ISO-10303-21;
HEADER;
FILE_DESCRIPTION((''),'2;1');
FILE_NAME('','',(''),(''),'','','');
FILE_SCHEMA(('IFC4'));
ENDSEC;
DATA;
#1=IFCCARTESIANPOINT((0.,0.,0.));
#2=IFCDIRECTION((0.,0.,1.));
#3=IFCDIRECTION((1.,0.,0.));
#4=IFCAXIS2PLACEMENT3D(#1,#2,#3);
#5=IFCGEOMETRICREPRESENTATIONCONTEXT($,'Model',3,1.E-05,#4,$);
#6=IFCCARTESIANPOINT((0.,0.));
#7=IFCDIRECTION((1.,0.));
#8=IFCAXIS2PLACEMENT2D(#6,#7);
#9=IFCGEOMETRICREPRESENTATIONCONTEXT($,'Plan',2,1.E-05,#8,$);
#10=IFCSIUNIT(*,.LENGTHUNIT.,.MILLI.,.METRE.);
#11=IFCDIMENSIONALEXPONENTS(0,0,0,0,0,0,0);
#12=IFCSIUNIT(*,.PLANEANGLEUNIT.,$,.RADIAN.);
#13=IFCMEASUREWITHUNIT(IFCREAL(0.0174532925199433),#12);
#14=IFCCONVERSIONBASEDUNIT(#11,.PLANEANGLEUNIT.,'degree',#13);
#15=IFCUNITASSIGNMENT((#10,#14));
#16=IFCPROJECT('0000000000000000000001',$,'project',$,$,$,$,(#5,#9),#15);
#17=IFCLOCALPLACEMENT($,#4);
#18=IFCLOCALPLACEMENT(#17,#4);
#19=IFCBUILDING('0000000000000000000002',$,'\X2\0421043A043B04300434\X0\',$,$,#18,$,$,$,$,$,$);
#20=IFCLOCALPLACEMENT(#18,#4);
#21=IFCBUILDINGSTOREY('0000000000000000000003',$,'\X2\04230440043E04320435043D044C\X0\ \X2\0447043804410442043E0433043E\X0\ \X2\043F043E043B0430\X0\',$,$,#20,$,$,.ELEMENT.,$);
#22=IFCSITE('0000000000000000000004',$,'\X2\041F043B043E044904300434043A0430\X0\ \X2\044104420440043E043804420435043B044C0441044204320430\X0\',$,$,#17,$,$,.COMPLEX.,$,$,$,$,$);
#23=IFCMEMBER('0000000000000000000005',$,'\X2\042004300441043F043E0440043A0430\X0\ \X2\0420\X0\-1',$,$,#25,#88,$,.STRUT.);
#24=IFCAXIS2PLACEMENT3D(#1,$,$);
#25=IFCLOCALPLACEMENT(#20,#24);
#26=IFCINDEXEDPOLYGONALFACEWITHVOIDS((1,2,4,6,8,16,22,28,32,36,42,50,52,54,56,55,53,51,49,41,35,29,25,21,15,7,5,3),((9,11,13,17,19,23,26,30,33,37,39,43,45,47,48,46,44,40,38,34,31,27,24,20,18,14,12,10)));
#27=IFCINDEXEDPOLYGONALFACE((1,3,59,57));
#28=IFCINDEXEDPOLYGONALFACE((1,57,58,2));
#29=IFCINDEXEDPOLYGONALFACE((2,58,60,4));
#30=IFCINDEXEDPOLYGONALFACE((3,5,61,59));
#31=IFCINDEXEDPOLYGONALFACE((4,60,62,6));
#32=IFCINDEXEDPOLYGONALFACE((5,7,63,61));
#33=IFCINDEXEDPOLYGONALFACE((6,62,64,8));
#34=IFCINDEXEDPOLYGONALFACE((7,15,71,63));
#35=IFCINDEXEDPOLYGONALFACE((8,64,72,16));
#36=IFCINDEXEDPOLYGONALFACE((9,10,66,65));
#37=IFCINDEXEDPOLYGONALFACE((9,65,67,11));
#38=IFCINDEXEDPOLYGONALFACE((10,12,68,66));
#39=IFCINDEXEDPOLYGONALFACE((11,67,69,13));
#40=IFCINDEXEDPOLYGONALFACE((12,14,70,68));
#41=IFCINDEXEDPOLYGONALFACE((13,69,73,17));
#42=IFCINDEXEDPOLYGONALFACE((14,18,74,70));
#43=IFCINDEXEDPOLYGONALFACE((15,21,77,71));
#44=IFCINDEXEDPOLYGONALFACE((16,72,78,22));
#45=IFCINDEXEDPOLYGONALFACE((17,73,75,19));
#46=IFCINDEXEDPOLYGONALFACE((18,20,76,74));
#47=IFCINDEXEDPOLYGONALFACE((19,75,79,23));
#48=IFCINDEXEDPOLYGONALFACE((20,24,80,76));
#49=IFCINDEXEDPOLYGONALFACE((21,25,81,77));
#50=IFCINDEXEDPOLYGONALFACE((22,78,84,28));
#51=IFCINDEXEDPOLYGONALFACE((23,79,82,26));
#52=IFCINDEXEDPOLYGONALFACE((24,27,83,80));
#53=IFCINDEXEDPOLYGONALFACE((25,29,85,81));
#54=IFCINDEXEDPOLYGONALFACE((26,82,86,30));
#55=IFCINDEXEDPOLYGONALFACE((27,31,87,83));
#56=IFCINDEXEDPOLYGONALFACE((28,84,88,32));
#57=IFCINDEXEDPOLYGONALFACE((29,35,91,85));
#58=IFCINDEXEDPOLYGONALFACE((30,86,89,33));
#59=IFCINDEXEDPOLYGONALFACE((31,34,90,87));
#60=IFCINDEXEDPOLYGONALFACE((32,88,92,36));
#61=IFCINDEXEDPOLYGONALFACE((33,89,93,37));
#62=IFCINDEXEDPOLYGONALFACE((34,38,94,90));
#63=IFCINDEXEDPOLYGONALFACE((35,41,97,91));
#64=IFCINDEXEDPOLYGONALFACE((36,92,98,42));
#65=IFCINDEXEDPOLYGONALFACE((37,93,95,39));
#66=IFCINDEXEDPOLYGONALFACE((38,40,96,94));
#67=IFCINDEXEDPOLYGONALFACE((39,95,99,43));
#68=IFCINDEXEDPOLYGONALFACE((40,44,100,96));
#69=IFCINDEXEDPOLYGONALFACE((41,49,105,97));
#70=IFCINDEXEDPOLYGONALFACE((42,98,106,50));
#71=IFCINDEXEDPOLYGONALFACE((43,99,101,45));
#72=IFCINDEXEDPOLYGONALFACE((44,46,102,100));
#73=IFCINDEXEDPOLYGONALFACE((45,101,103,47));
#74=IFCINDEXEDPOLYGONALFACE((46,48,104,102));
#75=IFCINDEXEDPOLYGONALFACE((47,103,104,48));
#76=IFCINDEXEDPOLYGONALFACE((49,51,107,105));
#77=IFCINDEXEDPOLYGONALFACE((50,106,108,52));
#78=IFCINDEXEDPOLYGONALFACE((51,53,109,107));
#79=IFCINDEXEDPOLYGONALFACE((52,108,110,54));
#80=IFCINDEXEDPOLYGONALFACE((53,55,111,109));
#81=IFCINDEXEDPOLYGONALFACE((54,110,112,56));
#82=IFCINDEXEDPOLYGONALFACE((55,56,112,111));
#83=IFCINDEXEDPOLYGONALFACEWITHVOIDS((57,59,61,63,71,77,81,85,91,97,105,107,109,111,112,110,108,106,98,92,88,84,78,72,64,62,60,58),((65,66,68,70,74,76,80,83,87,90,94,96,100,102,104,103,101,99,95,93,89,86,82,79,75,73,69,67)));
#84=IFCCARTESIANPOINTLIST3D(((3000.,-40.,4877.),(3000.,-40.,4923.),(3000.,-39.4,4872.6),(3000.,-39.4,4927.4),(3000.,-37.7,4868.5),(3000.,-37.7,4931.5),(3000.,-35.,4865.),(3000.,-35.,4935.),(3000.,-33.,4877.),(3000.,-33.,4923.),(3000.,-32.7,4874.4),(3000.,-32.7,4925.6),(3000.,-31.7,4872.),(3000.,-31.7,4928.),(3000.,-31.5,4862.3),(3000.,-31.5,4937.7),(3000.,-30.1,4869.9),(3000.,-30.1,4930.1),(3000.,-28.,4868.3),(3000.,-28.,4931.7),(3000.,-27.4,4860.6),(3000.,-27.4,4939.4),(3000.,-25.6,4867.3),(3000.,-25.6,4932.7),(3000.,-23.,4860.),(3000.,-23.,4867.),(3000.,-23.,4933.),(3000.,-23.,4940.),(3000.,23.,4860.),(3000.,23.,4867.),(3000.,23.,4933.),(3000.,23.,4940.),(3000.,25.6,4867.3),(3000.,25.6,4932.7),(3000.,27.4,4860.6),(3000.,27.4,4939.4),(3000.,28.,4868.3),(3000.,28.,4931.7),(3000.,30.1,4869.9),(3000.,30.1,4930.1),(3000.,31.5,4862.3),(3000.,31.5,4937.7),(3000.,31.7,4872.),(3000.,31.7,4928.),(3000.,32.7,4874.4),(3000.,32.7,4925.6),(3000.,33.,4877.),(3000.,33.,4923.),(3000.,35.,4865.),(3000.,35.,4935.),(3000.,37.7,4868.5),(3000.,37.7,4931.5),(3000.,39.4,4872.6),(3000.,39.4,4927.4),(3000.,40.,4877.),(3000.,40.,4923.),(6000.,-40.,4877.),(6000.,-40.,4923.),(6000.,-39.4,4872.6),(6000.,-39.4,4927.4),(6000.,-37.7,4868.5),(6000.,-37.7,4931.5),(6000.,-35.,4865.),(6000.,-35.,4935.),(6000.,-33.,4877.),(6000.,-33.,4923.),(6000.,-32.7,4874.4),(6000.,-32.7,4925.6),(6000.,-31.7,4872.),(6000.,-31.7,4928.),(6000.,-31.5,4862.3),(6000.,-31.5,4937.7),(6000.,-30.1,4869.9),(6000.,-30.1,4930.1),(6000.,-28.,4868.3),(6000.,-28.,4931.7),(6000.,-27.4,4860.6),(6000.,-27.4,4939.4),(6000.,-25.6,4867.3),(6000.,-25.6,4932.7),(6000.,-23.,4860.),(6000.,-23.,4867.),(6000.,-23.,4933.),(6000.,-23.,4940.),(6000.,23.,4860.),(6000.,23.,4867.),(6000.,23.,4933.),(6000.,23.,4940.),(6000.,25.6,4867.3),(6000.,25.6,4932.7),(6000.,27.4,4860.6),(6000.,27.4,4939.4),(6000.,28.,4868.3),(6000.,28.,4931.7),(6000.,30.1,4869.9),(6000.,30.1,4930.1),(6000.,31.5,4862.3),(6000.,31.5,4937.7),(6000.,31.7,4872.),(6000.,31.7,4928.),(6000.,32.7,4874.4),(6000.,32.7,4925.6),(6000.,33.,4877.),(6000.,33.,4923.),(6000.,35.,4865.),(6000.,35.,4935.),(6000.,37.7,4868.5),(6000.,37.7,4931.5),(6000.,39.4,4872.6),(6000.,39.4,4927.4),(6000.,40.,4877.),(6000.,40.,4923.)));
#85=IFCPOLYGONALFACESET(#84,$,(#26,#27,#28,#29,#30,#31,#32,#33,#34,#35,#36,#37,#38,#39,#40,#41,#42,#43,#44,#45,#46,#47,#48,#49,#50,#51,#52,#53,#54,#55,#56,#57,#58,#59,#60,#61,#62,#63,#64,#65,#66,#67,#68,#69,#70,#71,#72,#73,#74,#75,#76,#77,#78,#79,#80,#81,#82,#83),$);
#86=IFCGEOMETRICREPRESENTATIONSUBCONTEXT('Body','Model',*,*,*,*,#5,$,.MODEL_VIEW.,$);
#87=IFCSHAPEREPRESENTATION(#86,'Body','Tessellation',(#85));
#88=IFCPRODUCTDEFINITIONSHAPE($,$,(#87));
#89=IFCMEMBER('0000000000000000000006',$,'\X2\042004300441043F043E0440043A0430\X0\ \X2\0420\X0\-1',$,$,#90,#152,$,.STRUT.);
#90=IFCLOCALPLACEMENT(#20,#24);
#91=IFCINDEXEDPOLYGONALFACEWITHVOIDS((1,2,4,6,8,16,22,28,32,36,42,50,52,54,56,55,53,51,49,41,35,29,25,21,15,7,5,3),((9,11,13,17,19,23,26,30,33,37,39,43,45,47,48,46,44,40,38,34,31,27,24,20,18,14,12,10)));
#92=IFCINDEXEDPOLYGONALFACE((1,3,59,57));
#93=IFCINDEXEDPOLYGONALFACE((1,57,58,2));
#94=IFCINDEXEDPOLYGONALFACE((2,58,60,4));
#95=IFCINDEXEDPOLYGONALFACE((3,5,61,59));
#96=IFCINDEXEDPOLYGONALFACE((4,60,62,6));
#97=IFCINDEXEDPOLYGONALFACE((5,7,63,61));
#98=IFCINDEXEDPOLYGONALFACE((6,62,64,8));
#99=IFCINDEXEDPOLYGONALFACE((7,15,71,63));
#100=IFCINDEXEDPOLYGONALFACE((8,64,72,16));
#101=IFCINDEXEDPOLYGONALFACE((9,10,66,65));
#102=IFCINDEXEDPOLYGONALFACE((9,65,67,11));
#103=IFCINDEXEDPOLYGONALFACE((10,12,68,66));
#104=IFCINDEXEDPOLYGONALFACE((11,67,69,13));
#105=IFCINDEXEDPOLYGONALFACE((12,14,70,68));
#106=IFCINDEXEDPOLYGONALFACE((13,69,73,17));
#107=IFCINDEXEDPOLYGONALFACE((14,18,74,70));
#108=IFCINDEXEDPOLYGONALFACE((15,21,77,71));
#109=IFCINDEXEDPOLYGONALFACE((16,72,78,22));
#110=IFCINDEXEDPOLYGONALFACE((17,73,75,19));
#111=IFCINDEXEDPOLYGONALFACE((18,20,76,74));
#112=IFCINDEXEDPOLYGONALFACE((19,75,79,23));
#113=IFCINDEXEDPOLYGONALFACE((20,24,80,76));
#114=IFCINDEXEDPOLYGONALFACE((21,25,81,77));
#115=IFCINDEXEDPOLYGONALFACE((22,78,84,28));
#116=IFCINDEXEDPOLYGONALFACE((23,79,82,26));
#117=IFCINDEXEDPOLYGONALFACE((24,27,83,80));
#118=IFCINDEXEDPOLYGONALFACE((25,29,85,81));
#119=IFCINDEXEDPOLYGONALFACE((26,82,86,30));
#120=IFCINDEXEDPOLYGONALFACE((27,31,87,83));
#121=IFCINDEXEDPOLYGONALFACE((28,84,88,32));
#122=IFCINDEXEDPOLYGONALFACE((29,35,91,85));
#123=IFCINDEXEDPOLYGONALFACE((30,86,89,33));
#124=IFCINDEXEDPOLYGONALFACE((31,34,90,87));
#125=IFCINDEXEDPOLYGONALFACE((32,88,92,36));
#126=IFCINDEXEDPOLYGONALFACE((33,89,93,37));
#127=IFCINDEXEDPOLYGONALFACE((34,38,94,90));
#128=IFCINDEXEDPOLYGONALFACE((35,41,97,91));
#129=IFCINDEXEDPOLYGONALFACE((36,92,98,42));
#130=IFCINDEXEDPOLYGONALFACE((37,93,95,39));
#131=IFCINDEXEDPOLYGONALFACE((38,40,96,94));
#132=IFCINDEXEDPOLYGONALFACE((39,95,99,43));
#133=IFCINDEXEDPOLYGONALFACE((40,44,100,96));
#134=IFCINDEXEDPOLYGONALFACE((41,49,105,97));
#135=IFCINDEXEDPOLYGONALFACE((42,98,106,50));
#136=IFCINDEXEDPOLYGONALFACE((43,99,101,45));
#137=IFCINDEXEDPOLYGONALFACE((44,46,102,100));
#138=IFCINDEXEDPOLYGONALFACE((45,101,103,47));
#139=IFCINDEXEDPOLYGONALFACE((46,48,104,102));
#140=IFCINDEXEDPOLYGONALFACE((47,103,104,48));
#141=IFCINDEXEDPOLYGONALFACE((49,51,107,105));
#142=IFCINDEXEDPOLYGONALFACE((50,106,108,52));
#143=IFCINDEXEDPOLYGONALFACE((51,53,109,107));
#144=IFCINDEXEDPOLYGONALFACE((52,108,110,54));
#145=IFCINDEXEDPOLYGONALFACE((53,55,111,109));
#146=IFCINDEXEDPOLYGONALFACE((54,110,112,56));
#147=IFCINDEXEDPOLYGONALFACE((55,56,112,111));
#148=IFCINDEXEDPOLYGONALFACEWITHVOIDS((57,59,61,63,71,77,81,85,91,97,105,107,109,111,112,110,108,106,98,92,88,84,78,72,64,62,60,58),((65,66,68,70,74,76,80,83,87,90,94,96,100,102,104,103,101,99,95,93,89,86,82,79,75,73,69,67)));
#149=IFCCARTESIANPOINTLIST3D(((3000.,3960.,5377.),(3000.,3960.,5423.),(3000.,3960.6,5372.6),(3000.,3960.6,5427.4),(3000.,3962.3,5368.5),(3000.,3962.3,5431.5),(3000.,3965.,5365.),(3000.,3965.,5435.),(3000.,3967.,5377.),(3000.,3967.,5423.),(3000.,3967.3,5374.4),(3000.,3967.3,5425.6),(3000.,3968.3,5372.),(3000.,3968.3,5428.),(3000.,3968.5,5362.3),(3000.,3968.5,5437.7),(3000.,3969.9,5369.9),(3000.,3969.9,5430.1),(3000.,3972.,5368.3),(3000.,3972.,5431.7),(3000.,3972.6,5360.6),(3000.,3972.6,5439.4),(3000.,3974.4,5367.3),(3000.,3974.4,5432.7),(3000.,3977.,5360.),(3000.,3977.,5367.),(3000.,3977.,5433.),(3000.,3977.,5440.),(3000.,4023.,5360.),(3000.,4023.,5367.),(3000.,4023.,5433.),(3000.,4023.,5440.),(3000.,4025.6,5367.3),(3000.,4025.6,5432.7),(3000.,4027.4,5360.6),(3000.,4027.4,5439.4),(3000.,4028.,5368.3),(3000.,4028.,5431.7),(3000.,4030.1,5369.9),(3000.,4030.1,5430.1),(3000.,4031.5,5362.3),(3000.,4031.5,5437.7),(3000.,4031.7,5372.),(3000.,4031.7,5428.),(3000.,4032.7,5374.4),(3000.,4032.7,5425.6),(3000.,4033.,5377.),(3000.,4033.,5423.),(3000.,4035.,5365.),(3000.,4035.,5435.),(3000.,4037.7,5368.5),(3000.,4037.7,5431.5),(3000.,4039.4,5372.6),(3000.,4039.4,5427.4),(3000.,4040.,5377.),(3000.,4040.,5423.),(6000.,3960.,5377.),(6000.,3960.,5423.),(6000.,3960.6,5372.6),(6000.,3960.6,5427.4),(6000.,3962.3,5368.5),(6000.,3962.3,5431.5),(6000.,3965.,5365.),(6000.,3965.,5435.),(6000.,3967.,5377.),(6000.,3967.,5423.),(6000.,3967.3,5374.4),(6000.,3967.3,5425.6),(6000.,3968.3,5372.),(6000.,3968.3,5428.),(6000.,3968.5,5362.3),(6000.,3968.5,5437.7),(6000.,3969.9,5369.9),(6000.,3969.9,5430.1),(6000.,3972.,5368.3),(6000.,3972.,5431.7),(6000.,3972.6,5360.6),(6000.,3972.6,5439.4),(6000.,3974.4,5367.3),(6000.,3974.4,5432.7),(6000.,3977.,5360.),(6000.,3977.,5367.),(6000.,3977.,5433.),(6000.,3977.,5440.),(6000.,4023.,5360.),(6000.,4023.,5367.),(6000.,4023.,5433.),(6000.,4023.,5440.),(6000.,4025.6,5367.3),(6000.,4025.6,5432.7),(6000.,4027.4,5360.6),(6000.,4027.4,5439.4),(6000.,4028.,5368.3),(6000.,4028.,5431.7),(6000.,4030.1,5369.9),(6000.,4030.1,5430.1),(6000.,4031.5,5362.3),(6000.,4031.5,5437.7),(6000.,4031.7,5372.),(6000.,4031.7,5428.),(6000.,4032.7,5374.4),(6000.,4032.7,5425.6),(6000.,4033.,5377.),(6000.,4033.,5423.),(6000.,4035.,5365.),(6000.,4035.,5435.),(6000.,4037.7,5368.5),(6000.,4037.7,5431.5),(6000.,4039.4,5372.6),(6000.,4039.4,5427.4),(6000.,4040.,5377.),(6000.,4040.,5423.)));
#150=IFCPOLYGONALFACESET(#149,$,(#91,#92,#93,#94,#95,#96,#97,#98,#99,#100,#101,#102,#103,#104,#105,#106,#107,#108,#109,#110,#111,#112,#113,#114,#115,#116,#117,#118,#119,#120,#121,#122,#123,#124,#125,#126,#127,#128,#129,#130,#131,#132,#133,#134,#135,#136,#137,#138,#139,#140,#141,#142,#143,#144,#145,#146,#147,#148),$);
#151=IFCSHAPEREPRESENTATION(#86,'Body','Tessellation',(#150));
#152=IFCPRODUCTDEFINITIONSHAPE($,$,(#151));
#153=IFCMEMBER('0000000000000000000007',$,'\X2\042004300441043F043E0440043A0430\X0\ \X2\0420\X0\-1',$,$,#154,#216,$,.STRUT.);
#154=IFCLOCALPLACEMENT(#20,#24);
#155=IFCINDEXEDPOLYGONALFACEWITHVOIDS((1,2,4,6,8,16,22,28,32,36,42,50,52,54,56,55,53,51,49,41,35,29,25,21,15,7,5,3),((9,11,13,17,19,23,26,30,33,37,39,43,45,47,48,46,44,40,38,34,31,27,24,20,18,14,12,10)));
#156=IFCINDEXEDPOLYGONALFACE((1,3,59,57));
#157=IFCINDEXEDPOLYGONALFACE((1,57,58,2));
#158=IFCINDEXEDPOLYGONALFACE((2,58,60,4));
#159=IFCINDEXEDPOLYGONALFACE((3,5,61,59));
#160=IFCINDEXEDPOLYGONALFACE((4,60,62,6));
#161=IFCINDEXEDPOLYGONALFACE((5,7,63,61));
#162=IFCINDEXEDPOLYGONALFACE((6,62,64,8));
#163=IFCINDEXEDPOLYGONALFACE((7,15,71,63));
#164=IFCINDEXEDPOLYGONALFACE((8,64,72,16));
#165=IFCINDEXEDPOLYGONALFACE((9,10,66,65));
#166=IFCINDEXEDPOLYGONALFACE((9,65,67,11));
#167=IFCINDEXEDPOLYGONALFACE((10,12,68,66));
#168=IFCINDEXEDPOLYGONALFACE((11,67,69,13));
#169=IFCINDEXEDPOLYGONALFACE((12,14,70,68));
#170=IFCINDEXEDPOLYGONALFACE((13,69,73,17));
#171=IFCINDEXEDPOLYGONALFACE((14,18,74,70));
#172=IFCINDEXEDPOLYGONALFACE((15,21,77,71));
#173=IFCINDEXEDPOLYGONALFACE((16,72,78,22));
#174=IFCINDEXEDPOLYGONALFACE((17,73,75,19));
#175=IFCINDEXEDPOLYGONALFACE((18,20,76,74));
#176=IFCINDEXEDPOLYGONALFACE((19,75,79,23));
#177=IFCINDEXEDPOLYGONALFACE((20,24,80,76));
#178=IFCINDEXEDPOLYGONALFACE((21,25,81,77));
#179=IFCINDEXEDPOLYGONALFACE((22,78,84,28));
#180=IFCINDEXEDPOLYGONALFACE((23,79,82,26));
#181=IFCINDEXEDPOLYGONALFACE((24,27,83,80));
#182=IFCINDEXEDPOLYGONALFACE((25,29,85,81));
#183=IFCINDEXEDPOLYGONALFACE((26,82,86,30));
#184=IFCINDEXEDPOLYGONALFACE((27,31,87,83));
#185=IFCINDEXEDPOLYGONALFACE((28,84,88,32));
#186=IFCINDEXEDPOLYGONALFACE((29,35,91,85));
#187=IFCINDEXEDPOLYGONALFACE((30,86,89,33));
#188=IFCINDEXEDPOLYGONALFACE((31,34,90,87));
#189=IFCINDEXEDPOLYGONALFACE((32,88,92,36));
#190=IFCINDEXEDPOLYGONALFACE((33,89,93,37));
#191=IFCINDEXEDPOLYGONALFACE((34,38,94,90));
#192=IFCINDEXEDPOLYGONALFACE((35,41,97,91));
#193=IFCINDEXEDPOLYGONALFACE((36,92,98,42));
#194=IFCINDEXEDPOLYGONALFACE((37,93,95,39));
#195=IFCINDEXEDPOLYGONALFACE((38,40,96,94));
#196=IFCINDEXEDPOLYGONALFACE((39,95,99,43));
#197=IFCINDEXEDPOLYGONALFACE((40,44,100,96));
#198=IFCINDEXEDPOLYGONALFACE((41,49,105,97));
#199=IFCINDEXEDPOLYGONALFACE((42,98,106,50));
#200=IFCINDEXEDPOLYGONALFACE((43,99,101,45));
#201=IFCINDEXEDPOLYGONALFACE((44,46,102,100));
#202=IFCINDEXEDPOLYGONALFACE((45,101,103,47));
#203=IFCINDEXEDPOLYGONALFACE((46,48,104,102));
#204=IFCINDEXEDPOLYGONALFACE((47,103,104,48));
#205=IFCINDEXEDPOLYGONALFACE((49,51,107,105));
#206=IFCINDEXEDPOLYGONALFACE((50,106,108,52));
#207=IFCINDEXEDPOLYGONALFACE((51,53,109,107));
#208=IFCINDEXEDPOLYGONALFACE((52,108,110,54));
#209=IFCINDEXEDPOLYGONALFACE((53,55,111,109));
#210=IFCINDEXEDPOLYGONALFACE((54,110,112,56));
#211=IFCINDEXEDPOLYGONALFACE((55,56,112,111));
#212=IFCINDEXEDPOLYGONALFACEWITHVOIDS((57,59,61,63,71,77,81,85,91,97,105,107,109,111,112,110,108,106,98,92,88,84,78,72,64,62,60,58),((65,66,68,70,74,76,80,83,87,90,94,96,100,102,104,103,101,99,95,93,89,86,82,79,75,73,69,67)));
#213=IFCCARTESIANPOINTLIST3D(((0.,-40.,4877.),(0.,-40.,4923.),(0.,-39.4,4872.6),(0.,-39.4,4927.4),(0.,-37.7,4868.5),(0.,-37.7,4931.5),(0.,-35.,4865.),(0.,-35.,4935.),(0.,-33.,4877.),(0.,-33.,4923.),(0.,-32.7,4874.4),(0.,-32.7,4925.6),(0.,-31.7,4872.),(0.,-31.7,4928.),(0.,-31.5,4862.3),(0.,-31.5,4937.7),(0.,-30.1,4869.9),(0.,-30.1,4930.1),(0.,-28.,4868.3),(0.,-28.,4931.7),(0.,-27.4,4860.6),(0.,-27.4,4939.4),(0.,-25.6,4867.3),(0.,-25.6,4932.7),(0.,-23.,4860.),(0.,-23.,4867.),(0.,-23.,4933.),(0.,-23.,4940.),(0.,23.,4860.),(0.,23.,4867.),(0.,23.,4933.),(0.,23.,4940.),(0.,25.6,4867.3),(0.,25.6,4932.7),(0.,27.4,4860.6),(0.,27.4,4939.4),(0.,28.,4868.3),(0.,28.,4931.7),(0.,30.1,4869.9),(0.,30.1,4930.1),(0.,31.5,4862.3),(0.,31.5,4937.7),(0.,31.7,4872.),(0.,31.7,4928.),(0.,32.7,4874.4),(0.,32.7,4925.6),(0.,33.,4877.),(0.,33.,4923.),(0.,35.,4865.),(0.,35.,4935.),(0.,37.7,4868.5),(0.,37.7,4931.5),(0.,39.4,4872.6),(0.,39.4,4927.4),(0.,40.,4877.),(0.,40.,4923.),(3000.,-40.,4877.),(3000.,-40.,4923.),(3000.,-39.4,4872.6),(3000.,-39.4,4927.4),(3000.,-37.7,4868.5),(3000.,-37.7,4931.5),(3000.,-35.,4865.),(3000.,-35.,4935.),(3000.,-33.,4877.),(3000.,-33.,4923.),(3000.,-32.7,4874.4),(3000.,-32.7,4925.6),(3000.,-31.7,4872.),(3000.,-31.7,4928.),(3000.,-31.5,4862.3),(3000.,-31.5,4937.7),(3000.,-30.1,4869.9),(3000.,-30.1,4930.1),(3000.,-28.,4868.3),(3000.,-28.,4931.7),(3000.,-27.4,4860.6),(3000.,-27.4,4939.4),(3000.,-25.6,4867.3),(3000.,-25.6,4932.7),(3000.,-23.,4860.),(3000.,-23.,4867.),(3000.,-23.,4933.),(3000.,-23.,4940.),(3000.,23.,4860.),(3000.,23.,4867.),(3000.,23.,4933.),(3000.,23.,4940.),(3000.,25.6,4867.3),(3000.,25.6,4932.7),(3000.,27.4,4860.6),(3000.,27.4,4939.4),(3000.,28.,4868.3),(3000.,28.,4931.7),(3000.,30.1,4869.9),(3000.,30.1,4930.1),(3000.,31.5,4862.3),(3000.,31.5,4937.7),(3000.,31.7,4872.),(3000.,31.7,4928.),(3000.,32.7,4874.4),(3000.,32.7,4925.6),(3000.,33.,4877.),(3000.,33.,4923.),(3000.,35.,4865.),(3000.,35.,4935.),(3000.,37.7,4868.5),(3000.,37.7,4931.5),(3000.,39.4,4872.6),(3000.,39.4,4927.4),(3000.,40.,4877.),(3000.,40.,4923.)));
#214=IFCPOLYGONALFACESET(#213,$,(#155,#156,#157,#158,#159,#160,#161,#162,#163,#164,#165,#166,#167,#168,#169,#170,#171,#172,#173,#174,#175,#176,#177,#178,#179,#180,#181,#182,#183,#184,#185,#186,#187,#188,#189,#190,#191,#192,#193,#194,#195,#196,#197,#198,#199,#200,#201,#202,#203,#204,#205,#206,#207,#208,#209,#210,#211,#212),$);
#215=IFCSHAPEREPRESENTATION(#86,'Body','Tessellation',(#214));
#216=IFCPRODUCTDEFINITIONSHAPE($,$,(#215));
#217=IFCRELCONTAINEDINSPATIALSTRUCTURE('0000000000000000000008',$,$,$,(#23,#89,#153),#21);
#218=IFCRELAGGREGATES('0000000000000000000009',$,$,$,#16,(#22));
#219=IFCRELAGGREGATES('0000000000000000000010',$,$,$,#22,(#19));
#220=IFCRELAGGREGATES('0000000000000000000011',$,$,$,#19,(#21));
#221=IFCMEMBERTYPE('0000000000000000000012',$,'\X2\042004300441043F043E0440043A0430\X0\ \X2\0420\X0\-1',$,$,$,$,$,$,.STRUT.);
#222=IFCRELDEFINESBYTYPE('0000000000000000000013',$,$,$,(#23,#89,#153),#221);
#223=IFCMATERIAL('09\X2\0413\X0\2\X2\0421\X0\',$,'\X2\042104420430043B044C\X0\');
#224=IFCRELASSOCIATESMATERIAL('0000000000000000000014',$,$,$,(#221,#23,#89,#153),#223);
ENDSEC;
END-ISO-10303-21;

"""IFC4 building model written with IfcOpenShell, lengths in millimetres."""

from ifc_helpers import new_model, entity, si_unit, converted_unit, frame, origin_with_axes, origin_2d_with_axis, place, context, subcontext, project, spatial, hollow_rectangle, extrude, material, material_profile, profile_set, profile_usage, type_object, element, save


model = new_model("IFC4")

# Units and contexts
model_context = context("Model", 3, precision=1e-05, world=origin_with_axes())
plan_context = context("Plan", 2, precision=1e-05, world=origin_2d_with_axis())
body_context = subcontext(model_context, "Body", "Model", "MODEL_VIEW")
ifc_project = project(units=[si_unit("LENGTHUNIT", "METRE", prefix="MILLI"), converted_unit("PLANEANGLEUNIT", "degree", entity("IfcReal", 0.0174532925199433), si_unit("PLANEANGLEUNIT", "RADIAN"), dimensions=[0, 0, 0, 0, 0, 0, 0])], contexts=[model_context, plan_context])

# Site, building, storey
site_placement = place(None, origin_with_axes())
site = spatial("IfcSite", under=ifc_project, at=site_placement, Name="Площадка строительства", CompositionType="COMPLEX")
building_placement = place(site_placement, origin_with_axes())
building = spatial("IfcBuilding", under=site, at=building_placement, Name="Склад")
storey_placement = place(building_placement, origin_with_axes())
storey = spatial("IfcBuildingStorey", under=building, at=storey_placement, Name="Уровень чистого пола", CompositionType="ELEMENT")

# Members
ifc_material_1 = material(Name="09Г2С", Category="Сталь")
ifc_material_profile_1 = material_profile(ifc_material_1, hollow_rectangle(XDim=80.0, YDim=80.0, WallThickness=7.0, InnerFilletRadius=10.0, OuterFilletRadius=17.0))
ifc_profile_set_1 = profile_set([ifc_material_profile_1], Name="PK80x7_09G2S")
ifc_profile_usage_1 = profile_usage(ifc_profile_set_1, cardinal=5)
member_type_1 = type_object("IfcMemberType", Name="Распорка Р-1", PredefinedType="STRUT", material=ifc_profile_set_1)
for number, where, z_axis, x_axis, name in (
    (1, (3000.0, 0.0, 4900.0), (1.0, 0.0, 0.0), (0.0, 1.0, 0.0), "Распорка Р-1"),
    (2, (3000.0, 4000.0, 5400.0), (1.0, 0.0, 0.0), (0.0, 1.0, 0.0), "Распорка Р-1"),
    (3, (0.0, 0.0, 4900.0), (1.0, 0.0, 0.0), (0.0, 1.0, 0.0), "Распорка Р-1"),
):
    element("IfcMember", number, at=place(storey_placement, frame(where, z_axis=z_axis, x_axis=x_axis)), inside=storey, type_object=member_type_1, material=ifc_profile_usage_1, Name=name, PredefinedType="STRUT", context=body_context, shape_type="SweptSolid", body=[
        extrude(hollow_rectangle(XDim=80.0, YDim=80.0, WallThickness=7.0, InnerFilletRadius=10.0, OuterFilletRadius=17.0), origin_with_axes(), (0.0, 0.0, 1.0), 3000.0),
    ])

save(model, "model.ifc")
